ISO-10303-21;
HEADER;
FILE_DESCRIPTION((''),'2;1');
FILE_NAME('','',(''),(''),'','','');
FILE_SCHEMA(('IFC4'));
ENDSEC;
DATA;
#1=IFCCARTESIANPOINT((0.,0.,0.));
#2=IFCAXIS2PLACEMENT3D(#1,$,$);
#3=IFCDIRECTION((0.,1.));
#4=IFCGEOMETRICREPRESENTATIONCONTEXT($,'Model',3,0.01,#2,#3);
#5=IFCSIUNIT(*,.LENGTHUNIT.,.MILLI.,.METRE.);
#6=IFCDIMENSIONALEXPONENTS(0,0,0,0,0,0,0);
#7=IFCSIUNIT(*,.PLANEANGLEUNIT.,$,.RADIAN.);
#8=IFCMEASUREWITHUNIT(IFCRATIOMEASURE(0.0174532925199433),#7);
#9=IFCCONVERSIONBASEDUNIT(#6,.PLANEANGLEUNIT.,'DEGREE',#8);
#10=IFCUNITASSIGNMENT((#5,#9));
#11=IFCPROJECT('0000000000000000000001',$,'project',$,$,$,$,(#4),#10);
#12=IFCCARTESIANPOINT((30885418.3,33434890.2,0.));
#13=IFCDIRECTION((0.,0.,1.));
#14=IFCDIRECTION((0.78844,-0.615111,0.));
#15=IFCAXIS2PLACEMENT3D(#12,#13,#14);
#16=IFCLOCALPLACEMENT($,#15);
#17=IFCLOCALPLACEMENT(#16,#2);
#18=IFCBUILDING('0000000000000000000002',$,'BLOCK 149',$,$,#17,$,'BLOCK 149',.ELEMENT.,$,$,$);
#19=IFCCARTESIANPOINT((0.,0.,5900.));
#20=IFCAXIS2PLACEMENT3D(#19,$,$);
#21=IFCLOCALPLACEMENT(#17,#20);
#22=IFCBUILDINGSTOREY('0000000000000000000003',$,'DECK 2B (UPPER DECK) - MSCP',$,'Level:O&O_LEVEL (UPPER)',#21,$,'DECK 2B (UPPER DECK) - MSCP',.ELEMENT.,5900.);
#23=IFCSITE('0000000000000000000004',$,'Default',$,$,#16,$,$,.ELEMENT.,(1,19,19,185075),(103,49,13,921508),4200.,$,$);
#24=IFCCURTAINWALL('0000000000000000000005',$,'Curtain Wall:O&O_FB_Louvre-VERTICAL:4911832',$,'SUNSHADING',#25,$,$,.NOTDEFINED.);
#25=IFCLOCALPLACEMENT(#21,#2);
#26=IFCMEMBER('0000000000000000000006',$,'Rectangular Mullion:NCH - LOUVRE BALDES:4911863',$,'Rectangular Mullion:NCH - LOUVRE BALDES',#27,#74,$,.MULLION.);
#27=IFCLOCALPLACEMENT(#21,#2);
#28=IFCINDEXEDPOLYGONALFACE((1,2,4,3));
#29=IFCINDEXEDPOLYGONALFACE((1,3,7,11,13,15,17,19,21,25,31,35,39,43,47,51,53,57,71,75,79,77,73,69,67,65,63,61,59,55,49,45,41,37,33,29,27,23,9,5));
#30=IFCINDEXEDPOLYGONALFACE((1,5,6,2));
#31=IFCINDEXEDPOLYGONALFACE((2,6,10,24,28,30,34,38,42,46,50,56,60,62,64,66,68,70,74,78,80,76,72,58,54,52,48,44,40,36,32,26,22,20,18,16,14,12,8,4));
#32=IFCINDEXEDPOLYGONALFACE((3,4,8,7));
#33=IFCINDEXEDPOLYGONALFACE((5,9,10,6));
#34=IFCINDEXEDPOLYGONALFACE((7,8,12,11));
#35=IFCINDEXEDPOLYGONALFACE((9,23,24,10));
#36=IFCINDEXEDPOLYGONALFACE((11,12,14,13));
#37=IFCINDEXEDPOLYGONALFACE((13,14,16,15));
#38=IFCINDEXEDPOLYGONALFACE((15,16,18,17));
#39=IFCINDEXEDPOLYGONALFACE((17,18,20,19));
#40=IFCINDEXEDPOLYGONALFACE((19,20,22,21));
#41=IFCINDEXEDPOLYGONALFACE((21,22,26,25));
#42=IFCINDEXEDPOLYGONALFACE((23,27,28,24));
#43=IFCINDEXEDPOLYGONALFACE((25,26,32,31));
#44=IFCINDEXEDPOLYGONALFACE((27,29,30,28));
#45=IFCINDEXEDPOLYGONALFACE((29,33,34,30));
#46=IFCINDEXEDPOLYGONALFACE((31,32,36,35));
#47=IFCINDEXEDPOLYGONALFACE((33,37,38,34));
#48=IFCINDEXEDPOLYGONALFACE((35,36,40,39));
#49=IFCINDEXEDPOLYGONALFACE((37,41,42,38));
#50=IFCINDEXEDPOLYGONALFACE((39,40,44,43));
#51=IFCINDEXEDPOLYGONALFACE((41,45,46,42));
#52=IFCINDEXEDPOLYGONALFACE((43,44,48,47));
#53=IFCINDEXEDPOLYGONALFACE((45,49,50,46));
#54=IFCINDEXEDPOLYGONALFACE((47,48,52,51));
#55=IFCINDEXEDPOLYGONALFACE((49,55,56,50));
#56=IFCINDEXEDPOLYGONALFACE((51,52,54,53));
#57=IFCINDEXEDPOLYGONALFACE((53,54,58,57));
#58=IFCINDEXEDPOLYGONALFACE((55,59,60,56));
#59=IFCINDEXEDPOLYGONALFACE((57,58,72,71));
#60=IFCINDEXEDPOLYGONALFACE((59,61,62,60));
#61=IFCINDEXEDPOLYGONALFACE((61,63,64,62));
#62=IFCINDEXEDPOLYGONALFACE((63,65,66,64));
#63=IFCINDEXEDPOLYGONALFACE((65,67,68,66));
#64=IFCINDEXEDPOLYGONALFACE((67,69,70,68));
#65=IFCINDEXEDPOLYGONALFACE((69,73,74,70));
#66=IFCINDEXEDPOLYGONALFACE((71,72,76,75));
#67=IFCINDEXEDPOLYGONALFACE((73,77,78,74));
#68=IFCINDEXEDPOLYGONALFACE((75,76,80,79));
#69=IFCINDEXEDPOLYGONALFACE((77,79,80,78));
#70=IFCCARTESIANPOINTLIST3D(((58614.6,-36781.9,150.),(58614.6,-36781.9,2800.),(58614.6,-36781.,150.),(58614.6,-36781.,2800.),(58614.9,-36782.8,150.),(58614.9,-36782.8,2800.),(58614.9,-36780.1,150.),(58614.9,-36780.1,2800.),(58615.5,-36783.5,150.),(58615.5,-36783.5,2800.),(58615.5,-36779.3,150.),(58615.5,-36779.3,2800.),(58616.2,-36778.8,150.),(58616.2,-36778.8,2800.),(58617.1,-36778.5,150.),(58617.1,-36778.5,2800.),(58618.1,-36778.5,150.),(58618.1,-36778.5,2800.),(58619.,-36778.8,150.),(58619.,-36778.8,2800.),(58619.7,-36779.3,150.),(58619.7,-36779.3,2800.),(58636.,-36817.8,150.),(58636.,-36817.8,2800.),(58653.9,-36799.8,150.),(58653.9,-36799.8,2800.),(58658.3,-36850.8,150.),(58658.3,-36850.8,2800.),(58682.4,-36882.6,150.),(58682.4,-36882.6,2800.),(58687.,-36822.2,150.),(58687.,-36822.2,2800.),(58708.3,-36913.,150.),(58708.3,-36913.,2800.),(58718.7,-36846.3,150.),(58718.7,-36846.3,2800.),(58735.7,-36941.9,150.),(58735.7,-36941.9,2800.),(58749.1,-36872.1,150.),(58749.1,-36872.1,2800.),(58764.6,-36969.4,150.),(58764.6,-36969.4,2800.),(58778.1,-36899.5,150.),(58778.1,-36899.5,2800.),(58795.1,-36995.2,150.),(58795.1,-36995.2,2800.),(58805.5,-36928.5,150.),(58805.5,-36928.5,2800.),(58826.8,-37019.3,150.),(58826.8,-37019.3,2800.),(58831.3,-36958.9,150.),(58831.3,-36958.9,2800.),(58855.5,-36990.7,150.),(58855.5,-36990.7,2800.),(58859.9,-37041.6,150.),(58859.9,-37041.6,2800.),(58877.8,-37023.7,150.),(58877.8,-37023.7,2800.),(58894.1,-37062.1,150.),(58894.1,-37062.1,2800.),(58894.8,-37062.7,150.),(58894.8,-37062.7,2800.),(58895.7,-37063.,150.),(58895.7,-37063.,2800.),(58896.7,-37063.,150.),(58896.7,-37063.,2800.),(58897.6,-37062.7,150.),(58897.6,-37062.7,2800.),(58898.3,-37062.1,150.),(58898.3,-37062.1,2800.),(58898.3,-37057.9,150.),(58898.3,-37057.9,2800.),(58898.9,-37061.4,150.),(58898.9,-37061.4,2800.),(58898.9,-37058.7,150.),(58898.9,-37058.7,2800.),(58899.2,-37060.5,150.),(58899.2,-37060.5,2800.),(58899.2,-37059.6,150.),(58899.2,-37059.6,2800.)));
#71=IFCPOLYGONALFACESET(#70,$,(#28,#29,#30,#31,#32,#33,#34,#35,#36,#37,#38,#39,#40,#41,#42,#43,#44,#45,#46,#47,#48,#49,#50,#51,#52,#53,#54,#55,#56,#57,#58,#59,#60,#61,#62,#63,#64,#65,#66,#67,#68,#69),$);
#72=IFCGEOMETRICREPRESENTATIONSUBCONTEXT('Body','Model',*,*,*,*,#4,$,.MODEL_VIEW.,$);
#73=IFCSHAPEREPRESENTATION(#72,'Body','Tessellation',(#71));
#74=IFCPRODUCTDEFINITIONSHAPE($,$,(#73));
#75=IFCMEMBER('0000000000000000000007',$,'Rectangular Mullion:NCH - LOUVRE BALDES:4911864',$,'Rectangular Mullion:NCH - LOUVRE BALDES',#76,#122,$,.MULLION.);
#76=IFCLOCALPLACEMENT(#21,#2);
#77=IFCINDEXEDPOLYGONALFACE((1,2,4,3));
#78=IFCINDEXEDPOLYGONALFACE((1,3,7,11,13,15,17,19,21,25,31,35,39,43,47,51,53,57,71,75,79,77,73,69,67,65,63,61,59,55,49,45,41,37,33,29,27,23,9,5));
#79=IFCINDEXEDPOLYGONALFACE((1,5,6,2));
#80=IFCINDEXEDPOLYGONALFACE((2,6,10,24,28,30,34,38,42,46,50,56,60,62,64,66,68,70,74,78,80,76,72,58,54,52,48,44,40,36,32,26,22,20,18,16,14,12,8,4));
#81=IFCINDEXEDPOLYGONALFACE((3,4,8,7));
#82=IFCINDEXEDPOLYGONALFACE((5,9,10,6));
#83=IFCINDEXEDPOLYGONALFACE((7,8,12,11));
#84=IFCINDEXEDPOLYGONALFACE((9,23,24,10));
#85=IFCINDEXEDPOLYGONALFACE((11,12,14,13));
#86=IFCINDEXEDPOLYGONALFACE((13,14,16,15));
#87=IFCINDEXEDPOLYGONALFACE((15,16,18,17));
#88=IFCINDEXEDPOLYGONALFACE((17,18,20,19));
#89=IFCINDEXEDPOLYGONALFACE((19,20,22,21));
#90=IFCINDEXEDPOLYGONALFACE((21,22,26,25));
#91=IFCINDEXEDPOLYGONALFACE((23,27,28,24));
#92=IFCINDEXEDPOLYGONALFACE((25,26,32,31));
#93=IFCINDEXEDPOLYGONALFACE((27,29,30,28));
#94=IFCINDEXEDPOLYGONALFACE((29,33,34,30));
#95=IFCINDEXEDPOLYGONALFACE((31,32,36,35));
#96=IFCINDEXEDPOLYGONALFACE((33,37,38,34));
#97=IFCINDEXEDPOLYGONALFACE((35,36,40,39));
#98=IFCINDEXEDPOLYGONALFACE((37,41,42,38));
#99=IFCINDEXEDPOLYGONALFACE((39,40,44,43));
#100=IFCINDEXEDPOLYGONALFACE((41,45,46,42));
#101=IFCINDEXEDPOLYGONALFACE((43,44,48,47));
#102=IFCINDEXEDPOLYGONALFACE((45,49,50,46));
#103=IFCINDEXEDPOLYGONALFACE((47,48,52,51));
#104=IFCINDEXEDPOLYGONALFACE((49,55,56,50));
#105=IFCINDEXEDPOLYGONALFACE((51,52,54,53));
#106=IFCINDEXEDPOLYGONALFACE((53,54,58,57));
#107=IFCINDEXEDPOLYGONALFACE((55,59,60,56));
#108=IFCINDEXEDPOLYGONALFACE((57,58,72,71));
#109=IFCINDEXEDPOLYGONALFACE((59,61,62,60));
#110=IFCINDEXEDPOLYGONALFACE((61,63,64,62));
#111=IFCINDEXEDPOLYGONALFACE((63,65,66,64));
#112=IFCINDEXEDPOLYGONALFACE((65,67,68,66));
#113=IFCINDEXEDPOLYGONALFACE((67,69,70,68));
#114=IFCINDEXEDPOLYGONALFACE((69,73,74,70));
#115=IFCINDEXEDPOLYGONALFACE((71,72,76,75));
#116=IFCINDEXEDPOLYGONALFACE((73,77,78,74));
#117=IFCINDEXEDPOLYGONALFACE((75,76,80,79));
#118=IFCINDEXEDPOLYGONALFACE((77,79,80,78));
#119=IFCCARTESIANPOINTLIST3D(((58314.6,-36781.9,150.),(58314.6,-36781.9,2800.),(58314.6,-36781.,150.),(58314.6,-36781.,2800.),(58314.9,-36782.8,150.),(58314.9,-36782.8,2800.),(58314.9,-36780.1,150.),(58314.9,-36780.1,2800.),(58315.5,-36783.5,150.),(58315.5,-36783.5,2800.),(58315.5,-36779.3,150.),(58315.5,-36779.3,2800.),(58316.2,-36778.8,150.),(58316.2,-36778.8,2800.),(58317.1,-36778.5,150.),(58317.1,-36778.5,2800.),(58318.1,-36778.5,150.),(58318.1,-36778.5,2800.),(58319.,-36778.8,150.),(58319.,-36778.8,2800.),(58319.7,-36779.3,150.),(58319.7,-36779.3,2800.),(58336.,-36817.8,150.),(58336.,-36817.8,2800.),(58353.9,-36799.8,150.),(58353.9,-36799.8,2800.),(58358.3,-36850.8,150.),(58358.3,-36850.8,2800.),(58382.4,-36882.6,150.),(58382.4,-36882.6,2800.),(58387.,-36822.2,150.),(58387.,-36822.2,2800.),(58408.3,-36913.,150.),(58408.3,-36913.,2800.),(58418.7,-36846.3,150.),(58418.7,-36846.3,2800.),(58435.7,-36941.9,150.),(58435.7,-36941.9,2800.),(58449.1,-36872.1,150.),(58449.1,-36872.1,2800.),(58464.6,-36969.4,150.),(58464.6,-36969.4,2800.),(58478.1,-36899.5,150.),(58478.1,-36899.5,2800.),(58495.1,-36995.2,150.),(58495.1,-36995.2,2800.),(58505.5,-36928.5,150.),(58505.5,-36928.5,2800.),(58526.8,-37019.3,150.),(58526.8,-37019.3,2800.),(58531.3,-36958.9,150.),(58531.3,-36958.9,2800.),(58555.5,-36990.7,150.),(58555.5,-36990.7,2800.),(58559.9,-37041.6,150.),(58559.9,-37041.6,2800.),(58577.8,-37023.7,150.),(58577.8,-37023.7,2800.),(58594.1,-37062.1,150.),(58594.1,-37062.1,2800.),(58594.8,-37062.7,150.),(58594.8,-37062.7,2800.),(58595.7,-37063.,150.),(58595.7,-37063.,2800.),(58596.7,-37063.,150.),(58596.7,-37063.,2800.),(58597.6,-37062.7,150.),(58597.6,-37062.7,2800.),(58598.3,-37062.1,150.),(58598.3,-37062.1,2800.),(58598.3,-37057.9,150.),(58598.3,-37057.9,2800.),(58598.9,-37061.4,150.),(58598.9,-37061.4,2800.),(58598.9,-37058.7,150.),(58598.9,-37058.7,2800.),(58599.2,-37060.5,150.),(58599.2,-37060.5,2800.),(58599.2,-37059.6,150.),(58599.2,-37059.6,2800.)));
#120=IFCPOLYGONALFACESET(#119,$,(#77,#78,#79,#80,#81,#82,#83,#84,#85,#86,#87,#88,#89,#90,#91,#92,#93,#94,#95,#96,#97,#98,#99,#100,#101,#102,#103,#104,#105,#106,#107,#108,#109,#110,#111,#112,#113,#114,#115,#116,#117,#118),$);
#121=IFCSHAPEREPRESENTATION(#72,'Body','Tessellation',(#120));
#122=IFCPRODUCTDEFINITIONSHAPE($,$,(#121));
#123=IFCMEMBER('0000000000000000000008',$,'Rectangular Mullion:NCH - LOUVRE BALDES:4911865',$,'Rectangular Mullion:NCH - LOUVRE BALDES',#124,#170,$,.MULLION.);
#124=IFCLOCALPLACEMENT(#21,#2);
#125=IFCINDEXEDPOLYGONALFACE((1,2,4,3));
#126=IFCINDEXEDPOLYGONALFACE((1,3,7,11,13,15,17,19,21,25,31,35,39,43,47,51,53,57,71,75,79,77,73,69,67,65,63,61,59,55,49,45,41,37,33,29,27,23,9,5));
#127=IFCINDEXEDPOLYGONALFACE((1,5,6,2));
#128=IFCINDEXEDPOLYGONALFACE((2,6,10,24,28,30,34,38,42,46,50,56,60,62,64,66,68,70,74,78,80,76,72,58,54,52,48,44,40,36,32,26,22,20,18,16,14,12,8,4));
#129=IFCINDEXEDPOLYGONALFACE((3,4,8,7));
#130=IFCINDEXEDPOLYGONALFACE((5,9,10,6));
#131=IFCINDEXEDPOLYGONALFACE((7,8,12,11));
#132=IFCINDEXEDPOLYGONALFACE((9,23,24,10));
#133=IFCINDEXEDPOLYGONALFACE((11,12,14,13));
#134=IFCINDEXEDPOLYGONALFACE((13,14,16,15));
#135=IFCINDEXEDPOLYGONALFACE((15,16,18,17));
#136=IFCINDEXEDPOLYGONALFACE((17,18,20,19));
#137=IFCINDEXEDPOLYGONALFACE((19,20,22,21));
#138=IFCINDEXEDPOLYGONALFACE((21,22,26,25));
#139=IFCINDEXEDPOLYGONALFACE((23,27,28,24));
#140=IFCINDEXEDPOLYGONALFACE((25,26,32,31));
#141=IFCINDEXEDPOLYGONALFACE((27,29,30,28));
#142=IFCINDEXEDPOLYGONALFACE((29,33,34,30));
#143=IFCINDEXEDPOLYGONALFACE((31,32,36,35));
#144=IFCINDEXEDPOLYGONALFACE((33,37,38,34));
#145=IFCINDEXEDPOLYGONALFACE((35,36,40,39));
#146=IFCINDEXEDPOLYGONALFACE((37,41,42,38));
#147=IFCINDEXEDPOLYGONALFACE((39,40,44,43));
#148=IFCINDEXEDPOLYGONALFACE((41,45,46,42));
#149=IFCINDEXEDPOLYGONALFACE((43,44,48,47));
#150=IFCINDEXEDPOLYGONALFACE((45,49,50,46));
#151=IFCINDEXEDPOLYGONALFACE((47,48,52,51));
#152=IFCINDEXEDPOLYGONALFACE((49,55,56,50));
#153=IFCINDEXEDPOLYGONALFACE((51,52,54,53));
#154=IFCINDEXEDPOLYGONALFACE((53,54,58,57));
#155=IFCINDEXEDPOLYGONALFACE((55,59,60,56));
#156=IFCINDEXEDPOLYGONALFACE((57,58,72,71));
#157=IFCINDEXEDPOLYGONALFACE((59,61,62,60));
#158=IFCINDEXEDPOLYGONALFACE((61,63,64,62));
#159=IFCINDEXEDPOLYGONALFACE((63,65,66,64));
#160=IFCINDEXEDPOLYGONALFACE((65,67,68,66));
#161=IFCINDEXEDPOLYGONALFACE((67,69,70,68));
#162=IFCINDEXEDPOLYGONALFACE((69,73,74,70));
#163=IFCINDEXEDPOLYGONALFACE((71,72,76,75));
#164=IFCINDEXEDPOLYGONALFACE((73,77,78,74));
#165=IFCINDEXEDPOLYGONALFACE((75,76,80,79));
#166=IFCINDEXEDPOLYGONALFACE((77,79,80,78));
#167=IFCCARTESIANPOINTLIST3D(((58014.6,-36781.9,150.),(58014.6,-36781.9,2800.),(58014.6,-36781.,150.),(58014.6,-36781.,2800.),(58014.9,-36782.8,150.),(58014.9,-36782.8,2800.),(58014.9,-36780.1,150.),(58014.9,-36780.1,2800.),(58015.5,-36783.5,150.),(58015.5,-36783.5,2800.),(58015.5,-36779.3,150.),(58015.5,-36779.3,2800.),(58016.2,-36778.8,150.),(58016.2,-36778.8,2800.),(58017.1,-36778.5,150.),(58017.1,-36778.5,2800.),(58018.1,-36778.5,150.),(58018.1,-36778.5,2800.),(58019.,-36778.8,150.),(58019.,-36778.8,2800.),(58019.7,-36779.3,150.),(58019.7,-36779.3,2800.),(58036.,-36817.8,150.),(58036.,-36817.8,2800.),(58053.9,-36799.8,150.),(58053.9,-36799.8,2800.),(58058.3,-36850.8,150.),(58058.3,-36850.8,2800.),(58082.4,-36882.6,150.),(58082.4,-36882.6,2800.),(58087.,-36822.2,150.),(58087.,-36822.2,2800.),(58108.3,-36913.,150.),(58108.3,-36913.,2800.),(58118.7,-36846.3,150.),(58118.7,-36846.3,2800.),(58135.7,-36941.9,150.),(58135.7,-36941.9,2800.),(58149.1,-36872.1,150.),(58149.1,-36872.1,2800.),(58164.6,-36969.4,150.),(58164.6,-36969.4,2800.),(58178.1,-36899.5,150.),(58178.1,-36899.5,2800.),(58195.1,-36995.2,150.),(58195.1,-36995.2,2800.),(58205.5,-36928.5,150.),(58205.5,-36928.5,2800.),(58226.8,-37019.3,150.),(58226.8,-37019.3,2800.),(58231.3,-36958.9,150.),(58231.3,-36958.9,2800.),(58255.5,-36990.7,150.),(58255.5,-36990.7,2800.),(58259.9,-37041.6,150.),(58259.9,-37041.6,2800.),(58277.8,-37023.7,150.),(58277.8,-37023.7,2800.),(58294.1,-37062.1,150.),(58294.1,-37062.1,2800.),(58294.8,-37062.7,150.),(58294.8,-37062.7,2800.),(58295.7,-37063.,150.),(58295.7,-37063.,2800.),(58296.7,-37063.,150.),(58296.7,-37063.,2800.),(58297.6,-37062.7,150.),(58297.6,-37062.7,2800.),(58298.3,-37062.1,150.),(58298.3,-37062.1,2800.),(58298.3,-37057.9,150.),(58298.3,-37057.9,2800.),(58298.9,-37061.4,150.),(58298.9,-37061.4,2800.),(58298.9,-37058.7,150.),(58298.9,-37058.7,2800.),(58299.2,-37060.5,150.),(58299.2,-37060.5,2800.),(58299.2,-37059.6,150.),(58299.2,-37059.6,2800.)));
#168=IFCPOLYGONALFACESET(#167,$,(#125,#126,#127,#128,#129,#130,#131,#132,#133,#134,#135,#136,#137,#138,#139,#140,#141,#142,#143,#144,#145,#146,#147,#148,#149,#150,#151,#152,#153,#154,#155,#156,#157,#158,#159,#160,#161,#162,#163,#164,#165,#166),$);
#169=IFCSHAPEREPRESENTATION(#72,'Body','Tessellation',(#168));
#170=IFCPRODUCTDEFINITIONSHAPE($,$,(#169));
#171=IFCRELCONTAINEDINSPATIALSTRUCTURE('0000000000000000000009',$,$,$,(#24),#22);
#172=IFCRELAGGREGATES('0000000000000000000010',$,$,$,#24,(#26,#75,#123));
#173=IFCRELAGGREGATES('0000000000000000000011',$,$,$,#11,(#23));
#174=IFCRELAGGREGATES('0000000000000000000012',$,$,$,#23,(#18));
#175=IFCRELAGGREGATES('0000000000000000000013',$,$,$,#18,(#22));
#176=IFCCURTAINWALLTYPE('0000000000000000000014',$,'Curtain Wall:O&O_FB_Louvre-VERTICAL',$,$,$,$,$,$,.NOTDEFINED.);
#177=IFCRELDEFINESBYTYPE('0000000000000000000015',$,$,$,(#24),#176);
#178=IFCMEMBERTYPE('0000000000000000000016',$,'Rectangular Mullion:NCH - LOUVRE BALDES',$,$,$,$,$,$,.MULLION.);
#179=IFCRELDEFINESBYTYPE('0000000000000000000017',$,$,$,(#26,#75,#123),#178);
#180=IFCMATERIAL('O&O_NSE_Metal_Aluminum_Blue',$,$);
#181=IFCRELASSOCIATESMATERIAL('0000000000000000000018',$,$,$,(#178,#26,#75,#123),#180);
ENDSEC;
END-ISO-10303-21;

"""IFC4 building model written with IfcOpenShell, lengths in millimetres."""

from ifc_helpers import new_model, entity, si_unit, converted_unit, direction, frame, origin, place, context, subcontext, project, spatial, indexed_curve, outline, extrude, source, transform, mapped, material, type_object, type_shapes, element, aggregate, save


model = new_model("IFC4")

# Units and contexts
model_context = context("Model", 3, precision=0.01, world=origin(), true_north=direction((0.0, 1.0)))
body_context = subcontext(model_context, "Body", "Model", "MODEL_VIEW")
ifc_project = project(units=[si_unit("LENGTHUNIT", "METRE", prefix="MILLI"), converted_unit("PLANEANGLEUNIT", "DEGREE", entity("IfcRatioMeasure", 0.0174532925199433), si_unit("PLANEANGLEUNIT", "RADIAN"), dimensions=[0, 0, 0, 0, 0, 0, 0])], contexts=[model_context])

# Site, building, storey
site_placement = place(None, frame((30885418.3, 33434890.2, 0.0), z_axis=(0.0, 0.0, 1.0), x_axis=(0.78844, -0.615111, 0.0)))
site = spatial("IfcSite", under=ifc_project, at=site_placement, Name="Default", CompositionType="ELEMENT", RefLatitude=(1, 19, 19, 185075), RefLongitude=(103, 49, 13, 921508), RefElevation=4200.0)
building_placement = place(site_placement, origin())
building = spatial("IfcBuilding", under=site, at=building_placement, Name="BLOCK 149", LongName="BLOCK 149", CompositionType="ELEMENT")
storey_placement = place(building_placement, frame((0.0, 0.0, 5900.0)))
storey = spatial("IfcBuildingStorey", under=building, at=storey_placement, Name="DECK 2B (UPPER DECK) - MSCP", ObjectType="Level:O&O_LEVEL (UPPER)", LongName="DECK 2B (UPPER DECK) - MSCP", CompositionType="ELEMENT", Elevation=5900.0)

# Curtain wall, members
curtain_wall_type = type_object("IfcCurtainWallType", Name="Curtain Wall:O&O_FB_Louvre-VERTICAL", PredefinedType="NOTDEFINED")
curtain_wall_placement = place(storey_placement, frame((0.0, 0.0, -5900.0)))
curtain_wall = element("IfcCurtainWall", 1, at=curtain_wall_placement, inside=storey, type_object=curtain_wall_type, Name="Curtain Wall:O&O_FB_Louvre-VERTICAL:4911832", ObjectType="SUNSHADING", PredefinedType="NOTDEFINED")
placement = place(building_placement, origin())
ifc_material_1 = material(Name="O&O_NSE_Metal_Aluminum_Blue")
member_type_1 = type_object("IfcMemberType", Name="Rectangular Mullion:NCH - LOUVRE BALDES", PredefinedType="MULLION", material=ifc_material_1)
shared_shape_1 = source(origin(), body_context, "Body", "SweptSolid", [
    extrude(outline(indexed_curve([(55.9, -188.9), (54.8, -149.1), (51.6, -109.3), (46.1, -69.8), (38.6, -30.6), (28.9, 8.1), (17.1, 46.2), (3.3, 83.6), (-12.6, 120.2), (-30.4, 155.9), (-50.1, 190.5), (-50.5, 191.4), (-51.1, 192.1), (-52.0, 192.5), (-52.9, 192.7), (-53.8, 192.6), (-54.7, 192.2), (-55.4, 191.6), (-55.8, 190.8), (-56.0, 189.9), (-55.9, 188.9), (-54.8, 149.1), (-51.6, 109.3), (-46.1, 69.8), (-38.6, 30.6), (-28.9, -8.1), (-17.1, -46.2), (-3.3, -83.6), (12.6, -120.2), (30.4, -155.9), (50.1, -190.5), (50.5, -191.4), (51.1, -192.1), (52.0, -192.5), (52.9, -192.7), (53.8, -192.6), (54.7, -192.2), (55.4, -191.6), (55.8, -190.8), (56.0, -189.9), (55.9, -188.9)], self_intersect=False)), frame((0.0, 0.0, -2650.0), z_axis=(0.0, 0.0, 1.0), x_axis=(0.490779, -0.871284, 0.0)), (0.0, 0.0, 1.0), 2650.0),
])
type_shapes(member_type_1, [shared_shape_1])
member_1_placement = place(placement, frame((58756.9, -36920.7, 6050.0), z_axis=(0.0, 0.0, -1.0), x_axis=(-1.0, 0.0, 0.0)))
member_1 = element("IfcMember", 2, at=member_1_placement, type_object=member_type_1, material=ifc_material_1, Name="Rectangular Mullion:NCH - LOUVRE BALDES:4911863", ObjectType="Rectangular Mullion:NCH - LOUVRE BALDES", PredefinedType="MULLION", context=body_context, shape_type="MappedRepresentation", body=[
    mapped(shared_shape_1, transform((0.0, 0.0, 0.0), scale=1.0)),
])
member_2_placement = place(placement, frame((58456.9, -36920.7, 6050.0), z_axis=(0.0, 0.0, -1.0), x_axis=(-1.0, 0.0, 0.0)))
member_2 = element("IfcMember", 3, at=member_2_placement, type_object=member_type_1, material=ifc_material_1, Name="Rectangular Mullion:NCH - LOUVRE BALDES:4911864", ObjectType="Rectangular Mullion:NCH - LOUVRE BALDES", PredefinedType="MULLION", context=body_context, shape_type="MappedRepresentation", body=[
    mapped(shared_shape_1, transform((0.0, 0.0, 0.0), scale=1.0)),
])
member_3_placement = place(placement, frame((58156.9, -36920.7, 6050.0), z_axis=(0.0, 0.0, -1.0), x_axis=(-1.0, 0.0, 0.0)))
member_3 = element("IfcMember", 4, at=member_3_placement, type_object=member_type_1, material=ifc_material_1, Name="Rectangular Mullion:NCH - LOUVRE BALDES:4911865", ObjectType="Rectangular Mullion:NCH - LOUVRE BALDES", PredefinedType="MULLION", context=body_context, shape_type="MappedRepresentation", body=[
    mapped(shared_shape_1, transform((0.0, 0.0, 0.0), scale=1.0)),
])
aggregate(curtain_wall, [member_1, member_2, member_3])

save(model, "model.ifc")
